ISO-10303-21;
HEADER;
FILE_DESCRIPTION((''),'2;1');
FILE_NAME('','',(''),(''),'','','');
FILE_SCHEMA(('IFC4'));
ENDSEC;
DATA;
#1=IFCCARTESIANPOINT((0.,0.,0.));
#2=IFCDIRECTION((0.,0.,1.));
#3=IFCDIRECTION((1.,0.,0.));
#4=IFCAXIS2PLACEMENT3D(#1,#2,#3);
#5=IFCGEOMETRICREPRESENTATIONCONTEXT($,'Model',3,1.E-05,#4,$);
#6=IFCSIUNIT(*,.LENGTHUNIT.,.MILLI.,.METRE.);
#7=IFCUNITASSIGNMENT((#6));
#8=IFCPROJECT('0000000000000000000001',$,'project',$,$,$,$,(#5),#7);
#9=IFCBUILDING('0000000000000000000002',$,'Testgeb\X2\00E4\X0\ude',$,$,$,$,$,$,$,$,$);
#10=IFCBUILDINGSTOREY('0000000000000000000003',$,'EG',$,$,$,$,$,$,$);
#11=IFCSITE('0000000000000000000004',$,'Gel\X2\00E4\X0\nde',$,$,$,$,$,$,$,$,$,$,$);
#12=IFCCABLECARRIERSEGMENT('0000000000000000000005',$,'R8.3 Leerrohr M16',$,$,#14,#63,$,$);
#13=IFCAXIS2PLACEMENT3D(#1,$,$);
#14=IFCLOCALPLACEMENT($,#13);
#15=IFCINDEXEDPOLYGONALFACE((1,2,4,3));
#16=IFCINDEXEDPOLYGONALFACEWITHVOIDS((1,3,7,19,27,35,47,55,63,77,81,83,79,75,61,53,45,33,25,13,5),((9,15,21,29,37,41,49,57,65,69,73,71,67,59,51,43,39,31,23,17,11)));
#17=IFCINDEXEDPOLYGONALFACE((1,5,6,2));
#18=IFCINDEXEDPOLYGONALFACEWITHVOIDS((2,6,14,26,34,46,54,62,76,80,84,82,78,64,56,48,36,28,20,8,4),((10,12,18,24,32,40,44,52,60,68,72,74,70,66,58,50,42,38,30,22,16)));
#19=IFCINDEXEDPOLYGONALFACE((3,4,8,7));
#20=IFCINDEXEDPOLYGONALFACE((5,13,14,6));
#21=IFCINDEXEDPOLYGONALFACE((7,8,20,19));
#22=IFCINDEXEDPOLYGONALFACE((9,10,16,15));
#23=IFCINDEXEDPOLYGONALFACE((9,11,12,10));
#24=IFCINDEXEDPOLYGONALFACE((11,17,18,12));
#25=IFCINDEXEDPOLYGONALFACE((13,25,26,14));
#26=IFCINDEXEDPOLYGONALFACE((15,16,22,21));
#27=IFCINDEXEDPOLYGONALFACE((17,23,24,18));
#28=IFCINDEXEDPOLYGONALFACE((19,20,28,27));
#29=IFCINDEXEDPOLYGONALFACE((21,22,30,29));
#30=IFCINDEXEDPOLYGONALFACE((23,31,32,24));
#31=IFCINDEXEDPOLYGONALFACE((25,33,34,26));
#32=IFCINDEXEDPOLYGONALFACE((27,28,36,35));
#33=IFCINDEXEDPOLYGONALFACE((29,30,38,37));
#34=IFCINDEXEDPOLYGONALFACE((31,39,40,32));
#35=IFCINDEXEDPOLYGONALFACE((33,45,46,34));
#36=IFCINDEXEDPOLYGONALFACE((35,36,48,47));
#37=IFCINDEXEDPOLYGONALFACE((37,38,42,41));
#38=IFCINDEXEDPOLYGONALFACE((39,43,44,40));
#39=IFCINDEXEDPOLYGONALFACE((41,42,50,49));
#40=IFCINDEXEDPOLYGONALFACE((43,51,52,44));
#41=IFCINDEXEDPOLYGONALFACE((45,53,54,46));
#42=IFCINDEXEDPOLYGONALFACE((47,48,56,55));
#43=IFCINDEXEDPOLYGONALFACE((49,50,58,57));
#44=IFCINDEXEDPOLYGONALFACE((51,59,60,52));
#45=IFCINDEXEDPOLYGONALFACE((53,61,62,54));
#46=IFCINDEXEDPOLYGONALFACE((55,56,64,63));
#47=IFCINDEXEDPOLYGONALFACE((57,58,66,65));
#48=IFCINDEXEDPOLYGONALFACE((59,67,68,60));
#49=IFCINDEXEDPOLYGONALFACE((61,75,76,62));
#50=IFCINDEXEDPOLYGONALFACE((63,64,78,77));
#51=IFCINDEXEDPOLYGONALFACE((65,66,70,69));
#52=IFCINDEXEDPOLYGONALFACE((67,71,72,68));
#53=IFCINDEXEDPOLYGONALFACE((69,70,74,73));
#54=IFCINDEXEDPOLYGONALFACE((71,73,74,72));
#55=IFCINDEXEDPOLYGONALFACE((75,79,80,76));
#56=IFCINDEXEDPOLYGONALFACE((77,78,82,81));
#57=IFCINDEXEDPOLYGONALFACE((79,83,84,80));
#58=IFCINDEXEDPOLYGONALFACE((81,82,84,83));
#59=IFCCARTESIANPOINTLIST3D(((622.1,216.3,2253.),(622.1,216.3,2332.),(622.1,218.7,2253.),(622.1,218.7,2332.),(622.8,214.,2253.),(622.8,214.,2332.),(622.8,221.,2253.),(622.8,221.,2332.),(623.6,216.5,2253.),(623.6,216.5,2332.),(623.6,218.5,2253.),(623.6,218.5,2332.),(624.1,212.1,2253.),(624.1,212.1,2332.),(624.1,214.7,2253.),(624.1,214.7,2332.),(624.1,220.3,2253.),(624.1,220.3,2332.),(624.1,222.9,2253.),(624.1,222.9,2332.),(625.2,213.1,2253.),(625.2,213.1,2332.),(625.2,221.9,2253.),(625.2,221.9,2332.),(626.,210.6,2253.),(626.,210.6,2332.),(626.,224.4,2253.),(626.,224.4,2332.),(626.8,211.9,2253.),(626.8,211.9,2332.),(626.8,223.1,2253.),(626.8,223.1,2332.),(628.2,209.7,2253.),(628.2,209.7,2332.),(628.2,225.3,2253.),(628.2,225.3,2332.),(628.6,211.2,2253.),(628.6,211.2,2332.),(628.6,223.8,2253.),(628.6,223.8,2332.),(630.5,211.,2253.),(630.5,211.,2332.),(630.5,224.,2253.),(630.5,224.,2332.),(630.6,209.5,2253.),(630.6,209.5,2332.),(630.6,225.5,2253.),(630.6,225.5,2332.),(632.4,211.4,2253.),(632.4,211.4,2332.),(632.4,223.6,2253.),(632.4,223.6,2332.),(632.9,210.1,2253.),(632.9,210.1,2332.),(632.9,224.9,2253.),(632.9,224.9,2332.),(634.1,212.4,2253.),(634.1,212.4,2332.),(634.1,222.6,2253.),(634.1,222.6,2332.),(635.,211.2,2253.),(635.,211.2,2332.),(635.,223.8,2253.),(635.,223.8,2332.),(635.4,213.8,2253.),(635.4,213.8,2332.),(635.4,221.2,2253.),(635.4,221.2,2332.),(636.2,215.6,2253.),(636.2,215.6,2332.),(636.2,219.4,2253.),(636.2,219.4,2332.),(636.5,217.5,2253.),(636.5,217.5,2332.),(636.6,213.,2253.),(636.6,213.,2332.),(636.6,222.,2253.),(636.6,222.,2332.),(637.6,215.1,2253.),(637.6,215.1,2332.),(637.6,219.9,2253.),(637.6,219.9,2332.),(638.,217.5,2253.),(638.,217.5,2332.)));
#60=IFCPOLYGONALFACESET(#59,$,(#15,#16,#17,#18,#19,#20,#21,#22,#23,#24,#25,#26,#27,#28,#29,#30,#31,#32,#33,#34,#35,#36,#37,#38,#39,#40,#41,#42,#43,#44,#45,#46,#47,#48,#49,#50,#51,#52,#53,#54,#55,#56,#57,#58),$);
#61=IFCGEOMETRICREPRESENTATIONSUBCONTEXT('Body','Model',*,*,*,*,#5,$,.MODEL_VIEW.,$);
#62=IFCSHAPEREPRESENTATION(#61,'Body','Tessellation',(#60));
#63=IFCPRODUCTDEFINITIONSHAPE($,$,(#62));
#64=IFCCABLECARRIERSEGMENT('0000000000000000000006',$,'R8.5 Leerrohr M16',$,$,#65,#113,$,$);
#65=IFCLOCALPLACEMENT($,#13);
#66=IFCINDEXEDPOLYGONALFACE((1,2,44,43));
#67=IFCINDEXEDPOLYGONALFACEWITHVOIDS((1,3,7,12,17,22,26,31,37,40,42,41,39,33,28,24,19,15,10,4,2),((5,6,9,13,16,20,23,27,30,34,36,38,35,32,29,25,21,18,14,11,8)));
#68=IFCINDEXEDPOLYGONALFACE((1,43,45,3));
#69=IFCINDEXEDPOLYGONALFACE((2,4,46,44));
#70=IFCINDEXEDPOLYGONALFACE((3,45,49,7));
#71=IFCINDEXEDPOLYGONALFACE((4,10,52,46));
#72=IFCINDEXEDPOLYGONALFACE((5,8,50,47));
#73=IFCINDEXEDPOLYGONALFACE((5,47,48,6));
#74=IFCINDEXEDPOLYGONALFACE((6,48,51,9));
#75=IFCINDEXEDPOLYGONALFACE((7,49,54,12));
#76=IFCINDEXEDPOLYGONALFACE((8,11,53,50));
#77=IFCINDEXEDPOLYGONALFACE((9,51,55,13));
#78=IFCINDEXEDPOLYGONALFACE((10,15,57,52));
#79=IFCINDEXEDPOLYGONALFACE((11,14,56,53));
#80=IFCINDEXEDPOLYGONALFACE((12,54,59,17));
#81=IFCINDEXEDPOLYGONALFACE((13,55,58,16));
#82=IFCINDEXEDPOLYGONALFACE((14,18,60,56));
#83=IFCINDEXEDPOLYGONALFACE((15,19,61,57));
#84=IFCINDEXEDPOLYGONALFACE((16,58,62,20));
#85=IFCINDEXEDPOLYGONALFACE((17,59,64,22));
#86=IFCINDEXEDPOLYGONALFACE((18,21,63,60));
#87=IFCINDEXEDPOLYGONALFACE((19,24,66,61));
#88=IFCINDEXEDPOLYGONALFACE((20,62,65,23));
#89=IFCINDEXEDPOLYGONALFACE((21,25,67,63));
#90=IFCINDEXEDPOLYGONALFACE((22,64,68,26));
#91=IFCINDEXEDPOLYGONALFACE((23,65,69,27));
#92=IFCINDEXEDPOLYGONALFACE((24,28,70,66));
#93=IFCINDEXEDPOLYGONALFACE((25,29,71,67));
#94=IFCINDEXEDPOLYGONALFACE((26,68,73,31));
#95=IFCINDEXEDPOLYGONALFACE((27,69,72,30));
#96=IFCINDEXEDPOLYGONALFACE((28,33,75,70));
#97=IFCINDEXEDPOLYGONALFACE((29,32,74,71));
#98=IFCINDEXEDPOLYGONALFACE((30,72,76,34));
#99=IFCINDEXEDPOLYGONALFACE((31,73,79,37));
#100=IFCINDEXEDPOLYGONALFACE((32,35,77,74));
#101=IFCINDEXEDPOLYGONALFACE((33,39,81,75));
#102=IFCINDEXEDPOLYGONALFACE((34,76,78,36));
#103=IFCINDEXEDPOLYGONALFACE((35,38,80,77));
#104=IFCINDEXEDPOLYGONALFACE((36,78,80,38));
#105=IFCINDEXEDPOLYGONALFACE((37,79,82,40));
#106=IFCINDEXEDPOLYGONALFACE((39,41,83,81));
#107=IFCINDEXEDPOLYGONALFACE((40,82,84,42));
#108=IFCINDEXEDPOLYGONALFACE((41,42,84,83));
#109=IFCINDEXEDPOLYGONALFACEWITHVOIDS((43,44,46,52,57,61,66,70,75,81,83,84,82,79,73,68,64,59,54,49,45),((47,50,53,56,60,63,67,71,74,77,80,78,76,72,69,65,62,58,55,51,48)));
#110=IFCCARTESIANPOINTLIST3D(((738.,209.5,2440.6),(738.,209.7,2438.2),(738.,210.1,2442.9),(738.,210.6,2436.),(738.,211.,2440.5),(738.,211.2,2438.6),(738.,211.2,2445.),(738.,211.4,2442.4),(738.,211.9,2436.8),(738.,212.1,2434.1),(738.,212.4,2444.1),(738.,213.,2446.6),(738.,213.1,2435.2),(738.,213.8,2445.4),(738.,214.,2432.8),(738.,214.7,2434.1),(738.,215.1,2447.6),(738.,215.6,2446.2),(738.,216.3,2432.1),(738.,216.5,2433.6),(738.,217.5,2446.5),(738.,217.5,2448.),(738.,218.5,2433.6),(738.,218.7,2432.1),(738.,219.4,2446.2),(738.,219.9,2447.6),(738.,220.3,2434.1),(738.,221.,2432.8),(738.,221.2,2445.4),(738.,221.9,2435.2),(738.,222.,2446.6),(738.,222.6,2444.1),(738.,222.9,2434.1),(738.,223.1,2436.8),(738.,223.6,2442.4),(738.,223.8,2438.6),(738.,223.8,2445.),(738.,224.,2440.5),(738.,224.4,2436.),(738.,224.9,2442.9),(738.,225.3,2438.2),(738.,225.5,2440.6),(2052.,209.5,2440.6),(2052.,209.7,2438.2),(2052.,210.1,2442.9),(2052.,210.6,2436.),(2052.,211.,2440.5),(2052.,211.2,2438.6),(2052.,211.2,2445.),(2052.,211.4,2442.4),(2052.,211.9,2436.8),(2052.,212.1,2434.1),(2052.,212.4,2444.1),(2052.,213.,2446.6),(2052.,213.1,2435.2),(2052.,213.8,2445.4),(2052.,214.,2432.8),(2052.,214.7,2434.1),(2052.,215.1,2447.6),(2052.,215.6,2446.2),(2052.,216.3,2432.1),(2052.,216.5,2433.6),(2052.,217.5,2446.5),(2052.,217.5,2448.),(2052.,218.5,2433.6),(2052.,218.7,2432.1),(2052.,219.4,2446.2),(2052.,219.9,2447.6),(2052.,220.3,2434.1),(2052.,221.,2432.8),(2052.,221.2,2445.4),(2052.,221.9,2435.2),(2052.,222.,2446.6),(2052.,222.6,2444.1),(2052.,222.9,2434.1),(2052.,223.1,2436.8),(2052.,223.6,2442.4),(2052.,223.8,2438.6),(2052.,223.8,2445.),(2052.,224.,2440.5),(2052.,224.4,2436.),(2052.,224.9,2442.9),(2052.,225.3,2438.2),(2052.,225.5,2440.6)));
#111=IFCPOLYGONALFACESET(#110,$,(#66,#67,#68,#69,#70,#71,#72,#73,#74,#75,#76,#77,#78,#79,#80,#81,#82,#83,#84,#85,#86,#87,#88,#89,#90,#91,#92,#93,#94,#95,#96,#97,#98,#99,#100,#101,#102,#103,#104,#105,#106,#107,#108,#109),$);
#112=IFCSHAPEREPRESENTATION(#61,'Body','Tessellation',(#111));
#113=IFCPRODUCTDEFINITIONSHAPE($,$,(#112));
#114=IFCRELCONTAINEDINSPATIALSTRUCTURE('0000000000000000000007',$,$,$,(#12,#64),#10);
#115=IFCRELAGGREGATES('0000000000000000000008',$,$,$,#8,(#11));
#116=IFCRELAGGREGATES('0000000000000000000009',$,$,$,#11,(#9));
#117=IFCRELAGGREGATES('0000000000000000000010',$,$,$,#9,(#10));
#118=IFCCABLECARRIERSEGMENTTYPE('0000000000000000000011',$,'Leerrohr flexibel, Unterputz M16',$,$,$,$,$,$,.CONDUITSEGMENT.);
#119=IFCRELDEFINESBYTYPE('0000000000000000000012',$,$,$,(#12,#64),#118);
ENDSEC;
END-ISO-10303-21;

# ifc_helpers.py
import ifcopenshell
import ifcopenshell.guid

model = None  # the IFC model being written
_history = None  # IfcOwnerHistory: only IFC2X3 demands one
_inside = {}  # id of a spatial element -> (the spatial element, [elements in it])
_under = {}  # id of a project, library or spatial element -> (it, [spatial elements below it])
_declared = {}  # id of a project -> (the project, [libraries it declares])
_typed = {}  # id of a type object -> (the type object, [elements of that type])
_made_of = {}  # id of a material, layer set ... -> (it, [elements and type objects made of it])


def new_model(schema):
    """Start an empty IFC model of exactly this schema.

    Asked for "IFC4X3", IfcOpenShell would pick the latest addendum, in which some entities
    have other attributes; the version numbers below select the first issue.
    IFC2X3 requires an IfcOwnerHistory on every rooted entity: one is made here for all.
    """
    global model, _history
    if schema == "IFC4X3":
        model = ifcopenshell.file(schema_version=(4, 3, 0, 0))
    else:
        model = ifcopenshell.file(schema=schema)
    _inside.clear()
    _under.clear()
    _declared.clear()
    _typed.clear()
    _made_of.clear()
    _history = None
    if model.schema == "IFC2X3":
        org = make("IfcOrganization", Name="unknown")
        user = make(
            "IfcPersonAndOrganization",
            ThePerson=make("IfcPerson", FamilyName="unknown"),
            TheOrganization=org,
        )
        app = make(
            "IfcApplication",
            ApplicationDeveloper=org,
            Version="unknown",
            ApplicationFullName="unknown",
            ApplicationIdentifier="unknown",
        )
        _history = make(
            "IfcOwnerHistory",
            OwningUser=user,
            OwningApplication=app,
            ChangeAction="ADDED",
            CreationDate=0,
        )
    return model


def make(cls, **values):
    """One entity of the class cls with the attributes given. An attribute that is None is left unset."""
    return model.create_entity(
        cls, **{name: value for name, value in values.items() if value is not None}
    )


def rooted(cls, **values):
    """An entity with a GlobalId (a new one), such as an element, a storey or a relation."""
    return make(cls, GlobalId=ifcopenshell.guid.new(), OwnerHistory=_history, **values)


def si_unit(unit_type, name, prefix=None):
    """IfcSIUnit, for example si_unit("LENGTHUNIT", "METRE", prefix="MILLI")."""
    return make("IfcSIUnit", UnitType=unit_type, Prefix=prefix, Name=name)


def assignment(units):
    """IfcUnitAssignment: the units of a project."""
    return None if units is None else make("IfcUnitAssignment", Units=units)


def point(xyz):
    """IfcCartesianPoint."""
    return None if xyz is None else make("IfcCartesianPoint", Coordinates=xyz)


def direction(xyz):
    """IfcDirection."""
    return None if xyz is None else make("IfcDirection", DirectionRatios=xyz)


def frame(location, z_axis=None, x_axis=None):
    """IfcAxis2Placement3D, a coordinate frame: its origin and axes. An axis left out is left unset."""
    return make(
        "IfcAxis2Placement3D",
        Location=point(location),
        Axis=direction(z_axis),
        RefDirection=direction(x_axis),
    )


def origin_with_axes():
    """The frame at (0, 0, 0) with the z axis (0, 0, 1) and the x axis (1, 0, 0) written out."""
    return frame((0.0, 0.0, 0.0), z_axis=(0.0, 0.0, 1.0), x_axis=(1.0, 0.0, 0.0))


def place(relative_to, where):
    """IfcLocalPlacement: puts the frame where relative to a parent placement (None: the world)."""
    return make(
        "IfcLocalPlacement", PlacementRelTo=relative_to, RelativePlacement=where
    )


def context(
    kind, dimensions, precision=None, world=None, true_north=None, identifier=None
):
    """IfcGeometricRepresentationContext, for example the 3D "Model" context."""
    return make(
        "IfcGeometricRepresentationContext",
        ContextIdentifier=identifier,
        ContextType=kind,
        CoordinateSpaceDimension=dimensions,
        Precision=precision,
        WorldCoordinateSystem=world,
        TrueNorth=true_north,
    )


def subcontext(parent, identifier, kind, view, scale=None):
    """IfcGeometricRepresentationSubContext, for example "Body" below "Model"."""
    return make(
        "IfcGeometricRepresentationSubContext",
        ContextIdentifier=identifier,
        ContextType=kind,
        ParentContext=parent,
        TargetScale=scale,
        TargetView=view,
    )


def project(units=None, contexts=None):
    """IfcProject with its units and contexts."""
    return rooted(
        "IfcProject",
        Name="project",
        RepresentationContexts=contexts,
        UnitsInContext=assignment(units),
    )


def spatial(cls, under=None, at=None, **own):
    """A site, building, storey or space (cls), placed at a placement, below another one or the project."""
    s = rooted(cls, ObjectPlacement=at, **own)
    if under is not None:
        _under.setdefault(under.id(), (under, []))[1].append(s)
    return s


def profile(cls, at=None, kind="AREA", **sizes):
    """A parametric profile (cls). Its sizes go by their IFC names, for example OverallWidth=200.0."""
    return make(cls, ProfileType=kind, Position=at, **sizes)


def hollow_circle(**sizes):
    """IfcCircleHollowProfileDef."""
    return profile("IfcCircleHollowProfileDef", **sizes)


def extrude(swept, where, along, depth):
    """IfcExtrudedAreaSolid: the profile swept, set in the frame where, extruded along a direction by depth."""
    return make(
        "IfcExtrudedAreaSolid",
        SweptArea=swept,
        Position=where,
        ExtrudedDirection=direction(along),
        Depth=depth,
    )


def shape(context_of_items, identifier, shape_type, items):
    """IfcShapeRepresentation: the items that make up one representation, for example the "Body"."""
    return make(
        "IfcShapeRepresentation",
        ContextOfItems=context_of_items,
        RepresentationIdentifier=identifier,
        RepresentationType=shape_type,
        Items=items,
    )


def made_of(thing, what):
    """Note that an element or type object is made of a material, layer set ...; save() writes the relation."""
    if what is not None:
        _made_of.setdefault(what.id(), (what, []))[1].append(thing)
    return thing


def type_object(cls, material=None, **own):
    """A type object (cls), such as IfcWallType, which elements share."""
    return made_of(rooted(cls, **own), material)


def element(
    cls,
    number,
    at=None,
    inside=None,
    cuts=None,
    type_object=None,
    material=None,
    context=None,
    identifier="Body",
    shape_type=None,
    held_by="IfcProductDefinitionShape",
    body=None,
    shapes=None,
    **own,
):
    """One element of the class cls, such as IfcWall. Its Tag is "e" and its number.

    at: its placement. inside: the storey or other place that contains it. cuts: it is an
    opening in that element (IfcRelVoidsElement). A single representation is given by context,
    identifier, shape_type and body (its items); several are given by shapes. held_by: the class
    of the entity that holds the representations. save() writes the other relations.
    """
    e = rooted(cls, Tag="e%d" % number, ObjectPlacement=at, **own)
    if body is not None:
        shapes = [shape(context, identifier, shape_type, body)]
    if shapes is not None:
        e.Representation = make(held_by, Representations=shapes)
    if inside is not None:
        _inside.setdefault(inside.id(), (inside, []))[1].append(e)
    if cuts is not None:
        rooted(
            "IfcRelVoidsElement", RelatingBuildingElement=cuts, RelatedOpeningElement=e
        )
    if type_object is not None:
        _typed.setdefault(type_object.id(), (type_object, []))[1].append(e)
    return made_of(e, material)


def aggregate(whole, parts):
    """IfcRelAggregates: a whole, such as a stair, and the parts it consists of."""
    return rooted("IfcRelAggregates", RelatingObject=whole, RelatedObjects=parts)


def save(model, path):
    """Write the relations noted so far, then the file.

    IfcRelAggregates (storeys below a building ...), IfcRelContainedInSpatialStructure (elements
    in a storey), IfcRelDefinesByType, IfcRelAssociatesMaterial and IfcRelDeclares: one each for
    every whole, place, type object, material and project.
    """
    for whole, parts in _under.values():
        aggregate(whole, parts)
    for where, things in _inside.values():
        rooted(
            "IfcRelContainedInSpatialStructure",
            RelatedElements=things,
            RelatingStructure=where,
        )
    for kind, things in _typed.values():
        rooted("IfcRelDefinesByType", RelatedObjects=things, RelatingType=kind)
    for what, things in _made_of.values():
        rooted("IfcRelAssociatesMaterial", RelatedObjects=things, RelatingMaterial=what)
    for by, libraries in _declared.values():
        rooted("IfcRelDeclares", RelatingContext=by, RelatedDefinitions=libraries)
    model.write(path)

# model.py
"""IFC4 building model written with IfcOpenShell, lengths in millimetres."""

from ifc_helpers import new_model, si_unit, frame, origin_with_axes, place, context, subcontext, project, spatial, hollow_circle, extrude, type_object, element, save


model = new_model("IFC4")

# Units and contexts
model_context = context("Model", 3, precision=1e-05, world=origin_with_axes())
body_context = subcontext(model_context, "Body", "Model", "MODEL_VIEW")
ifc_project = project(units=[si_unit("LENGTHUNIT", "METRE", prefix="MILLI")], contexts=[model_context])

# Site, building, storey
site = spatial("IfcSite", under=ifc_project, Name="Gelände")
building = spatial("IfcBuilding", under=site, Name="Testgebäude")
storey = spatial("IfcBuildingStorey", under=building, Name="EG")

# Cable carrier segments
cable_carrier_segment_type_1 = type_object("IfcCableCarrierSegmentType", Name="Leerrohr flexibel, Unterputz M16", PredefinedType="CONDUITSEGMENT")
cable_carrier_segment_1_placement = place(None, frame((630.0, 217.5, 2253.0), z_axis=(0.0, 0.0, 1.0), x_axis=(1.0, 0.0, 0.0)))
element("IfcCableCarrierSegment", 1, at=cable_carrier_segment_1_placement, inside=storey, type_object=cable_carrier_segment_type_1, Name="R8.3 Leerrohr M16", context=body_context, shape_type="SweptSolid", body=[
    extrude(hollow_circle(Radius=8.0, WallThickness=1.5), None, (0.0, 0.0, 1.0), 79.0),
])
cable_carrier_segment_2_placement = place(None, frame((738.0, 217.5, 2440.0), z_axis=(1.0, 0.0, 0.0), x_axis=(0.0, 0.0, 1.0)))
element("IfcCableCarrierSegment", 2, at=cable_carrier_segment_2_placement, inside=storey, type_object=cable_carrier_segment_type_1, Name="R8.5 Leerrohr M16", context=body_context, shape_type="SweptSolid", body=[
    extrude(hollow_circle(Radius=8.0, WallThickness=1.5), None, (0.0, 0.0, 1.0), 1314.0),
])

save(model, "model.ifc")
